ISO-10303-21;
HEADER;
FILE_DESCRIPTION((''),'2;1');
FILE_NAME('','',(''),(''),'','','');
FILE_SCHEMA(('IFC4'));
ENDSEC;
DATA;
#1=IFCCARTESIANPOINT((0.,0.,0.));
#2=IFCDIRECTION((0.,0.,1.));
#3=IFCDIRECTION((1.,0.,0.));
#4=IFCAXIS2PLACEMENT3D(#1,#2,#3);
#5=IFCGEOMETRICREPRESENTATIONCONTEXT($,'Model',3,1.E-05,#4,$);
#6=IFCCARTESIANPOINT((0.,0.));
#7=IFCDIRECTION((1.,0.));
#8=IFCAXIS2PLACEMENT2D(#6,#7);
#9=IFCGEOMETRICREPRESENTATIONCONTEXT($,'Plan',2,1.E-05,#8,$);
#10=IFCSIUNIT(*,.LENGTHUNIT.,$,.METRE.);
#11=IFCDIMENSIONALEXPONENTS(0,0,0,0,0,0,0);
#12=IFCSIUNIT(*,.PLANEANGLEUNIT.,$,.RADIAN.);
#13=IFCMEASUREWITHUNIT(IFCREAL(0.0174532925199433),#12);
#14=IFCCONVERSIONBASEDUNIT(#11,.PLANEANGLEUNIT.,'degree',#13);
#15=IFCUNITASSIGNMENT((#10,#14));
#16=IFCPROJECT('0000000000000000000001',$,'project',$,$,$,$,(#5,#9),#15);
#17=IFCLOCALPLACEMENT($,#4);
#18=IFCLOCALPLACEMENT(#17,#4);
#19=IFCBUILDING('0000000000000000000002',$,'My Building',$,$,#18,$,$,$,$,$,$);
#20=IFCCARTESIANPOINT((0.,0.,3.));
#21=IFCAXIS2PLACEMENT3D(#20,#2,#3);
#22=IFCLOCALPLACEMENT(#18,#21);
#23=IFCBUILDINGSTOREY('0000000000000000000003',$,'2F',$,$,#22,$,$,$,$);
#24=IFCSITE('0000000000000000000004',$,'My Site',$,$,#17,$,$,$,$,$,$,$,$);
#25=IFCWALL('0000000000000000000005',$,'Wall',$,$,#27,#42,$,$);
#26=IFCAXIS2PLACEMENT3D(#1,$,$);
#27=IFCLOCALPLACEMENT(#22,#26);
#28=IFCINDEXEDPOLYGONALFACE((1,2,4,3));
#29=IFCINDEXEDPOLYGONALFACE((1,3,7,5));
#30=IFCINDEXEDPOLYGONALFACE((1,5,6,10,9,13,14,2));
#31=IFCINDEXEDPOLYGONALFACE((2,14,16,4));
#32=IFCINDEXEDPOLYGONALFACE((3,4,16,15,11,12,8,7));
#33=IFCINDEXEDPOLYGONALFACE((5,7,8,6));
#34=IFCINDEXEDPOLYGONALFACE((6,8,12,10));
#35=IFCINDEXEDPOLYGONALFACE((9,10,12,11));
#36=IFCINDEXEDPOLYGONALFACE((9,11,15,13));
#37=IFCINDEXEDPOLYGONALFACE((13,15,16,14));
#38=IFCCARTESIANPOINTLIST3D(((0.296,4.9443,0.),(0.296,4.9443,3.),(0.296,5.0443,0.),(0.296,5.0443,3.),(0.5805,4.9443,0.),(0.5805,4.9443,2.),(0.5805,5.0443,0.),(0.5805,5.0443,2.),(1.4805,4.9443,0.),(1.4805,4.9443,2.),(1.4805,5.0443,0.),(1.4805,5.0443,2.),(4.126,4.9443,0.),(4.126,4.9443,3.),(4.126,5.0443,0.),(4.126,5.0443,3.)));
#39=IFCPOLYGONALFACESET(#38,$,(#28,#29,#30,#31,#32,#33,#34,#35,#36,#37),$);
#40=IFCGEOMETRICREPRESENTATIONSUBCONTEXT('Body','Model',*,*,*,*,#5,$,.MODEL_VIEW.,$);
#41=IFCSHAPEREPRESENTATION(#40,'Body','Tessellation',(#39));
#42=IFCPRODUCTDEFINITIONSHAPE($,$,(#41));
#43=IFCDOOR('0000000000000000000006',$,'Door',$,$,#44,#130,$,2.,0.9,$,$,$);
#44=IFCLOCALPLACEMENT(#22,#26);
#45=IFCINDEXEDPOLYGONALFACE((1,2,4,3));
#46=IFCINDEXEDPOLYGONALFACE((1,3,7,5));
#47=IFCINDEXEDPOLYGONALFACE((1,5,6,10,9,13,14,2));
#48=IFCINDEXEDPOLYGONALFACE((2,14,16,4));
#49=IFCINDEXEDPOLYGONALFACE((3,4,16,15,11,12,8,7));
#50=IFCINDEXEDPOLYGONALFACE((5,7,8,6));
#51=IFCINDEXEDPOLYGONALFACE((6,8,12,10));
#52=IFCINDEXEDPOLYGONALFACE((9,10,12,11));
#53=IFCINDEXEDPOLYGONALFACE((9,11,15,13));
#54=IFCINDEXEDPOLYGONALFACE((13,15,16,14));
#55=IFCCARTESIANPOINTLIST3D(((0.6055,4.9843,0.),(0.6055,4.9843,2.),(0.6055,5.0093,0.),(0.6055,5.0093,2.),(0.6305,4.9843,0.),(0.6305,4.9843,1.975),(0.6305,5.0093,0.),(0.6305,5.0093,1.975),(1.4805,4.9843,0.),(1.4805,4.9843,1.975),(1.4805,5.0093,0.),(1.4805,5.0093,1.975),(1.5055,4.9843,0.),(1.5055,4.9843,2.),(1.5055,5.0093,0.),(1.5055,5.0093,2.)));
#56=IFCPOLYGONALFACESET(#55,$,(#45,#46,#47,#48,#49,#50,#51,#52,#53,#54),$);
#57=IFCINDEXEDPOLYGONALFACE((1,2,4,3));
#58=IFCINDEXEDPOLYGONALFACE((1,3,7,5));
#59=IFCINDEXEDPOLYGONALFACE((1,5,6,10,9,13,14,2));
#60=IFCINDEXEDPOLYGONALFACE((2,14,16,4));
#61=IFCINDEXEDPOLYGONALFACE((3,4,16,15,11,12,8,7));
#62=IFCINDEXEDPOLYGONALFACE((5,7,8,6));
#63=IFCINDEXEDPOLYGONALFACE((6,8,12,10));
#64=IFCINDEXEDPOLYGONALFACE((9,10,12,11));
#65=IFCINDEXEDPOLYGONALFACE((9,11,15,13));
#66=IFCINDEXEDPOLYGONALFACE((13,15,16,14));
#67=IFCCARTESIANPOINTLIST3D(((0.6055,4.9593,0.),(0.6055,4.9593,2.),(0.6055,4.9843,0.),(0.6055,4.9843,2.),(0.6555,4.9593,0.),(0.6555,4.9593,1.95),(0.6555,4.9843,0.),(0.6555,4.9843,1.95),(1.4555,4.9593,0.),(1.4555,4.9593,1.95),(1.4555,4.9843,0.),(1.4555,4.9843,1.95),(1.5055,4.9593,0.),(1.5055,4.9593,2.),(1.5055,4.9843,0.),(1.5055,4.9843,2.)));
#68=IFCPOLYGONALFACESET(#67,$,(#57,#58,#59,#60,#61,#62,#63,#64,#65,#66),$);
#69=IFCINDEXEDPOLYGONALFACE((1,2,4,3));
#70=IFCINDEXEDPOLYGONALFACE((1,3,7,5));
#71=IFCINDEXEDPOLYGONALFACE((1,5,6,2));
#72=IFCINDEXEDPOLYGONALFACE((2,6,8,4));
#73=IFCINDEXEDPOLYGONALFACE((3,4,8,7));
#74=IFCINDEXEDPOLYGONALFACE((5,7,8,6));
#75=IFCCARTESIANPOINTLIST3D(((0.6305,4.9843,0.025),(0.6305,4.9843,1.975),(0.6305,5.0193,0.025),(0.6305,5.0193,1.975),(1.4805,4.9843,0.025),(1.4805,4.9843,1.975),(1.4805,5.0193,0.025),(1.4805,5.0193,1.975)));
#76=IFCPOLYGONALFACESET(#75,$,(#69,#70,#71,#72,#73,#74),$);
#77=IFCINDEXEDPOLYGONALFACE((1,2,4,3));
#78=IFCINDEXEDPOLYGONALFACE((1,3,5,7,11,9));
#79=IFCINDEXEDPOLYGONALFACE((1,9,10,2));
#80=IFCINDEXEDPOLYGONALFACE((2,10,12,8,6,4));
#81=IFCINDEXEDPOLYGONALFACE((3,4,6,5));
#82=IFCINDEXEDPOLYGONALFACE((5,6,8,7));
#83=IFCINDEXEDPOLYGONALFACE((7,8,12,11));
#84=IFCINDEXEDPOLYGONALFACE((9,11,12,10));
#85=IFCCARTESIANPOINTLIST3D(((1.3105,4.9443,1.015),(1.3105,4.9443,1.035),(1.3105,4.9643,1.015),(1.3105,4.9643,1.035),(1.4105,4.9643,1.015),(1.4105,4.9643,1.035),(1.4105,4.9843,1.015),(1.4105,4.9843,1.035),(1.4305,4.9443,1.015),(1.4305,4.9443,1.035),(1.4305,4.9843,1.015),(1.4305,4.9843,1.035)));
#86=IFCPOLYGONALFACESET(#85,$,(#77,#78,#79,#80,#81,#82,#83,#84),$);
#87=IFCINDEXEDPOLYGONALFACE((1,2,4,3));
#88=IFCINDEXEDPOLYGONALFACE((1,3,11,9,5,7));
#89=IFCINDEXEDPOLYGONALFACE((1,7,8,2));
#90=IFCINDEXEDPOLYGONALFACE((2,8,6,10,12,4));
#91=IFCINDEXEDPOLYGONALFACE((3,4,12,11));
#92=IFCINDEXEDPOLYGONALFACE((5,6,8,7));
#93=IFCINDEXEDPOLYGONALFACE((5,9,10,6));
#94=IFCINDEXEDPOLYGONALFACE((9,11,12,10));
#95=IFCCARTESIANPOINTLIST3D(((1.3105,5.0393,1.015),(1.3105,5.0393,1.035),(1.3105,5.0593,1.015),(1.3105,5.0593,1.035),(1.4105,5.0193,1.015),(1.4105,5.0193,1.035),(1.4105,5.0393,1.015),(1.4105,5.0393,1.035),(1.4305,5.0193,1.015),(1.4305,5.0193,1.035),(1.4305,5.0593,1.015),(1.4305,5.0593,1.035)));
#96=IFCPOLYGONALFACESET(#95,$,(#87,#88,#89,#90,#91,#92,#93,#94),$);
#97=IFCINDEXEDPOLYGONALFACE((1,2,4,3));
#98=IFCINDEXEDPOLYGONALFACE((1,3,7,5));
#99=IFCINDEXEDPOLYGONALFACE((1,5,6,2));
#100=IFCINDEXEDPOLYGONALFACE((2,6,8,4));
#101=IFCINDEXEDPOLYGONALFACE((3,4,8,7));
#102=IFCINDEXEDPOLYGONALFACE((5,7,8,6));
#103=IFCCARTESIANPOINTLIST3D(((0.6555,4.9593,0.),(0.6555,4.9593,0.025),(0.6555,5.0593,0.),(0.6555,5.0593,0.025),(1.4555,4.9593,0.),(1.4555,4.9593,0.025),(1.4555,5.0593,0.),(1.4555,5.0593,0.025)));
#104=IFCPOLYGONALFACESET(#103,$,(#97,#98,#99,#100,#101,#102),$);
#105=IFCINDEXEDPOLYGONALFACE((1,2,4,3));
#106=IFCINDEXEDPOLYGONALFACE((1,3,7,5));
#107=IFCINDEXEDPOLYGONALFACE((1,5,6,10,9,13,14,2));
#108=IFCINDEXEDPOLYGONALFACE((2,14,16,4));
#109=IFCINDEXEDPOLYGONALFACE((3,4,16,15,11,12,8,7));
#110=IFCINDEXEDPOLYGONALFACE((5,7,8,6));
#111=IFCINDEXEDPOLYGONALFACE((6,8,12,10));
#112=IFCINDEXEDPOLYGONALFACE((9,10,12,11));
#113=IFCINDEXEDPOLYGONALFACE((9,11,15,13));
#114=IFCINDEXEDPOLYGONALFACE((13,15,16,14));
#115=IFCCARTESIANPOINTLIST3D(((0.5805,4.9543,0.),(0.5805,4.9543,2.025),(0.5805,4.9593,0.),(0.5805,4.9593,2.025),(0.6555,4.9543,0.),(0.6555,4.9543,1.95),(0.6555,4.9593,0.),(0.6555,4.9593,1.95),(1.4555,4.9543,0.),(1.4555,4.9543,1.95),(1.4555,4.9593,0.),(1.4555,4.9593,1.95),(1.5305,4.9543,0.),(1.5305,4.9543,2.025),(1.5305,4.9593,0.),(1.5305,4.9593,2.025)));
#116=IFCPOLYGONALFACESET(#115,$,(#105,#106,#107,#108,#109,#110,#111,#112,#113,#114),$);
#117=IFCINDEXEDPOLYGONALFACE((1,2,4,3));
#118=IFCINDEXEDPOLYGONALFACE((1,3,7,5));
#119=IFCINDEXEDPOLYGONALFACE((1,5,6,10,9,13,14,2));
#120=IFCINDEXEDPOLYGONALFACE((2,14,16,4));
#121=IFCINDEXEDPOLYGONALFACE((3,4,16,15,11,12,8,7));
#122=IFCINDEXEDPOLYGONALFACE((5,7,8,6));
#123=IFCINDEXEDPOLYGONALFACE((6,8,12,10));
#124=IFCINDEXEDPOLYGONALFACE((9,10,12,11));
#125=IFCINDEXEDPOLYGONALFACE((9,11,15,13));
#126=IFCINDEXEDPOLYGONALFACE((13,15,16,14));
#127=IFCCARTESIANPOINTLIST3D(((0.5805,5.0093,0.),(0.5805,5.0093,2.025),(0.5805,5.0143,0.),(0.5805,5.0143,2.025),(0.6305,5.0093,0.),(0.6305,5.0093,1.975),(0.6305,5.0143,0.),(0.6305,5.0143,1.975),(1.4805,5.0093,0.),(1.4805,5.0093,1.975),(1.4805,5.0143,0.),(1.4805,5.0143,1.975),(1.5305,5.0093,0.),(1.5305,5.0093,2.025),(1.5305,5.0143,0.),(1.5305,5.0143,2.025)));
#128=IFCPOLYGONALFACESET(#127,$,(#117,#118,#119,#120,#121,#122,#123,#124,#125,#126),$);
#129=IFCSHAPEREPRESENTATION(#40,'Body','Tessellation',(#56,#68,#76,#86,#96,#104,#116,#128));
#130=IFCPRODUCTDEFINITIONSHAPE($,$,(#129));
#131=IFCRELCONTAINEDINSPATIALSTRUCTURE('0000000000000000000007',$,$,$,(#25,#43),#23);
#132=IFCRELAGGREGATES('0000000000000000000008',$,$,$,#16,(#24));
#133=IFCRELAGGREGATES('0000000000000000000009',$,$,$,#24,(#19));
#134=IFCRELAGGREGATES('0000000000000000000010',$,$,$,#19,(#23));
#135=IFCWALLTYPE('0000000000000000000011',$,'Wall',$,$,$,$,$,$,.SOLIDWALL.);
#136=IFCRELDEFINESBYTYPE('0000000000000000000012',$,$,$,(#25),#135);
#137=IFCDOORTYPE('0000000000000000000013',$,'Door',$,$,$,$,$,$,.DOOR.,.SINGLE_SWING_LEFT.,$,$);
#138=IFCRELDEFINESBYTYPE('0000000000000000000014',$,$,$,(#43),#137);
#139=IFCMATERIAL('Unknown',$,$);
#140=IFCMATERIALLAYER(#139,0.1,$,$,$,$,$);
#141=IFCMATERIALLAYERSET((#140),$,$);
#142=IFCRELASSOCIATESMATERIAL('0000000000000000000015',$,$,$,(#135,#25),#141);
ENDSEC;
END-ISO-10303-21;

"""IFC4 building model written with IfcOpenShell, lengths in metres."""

from ifc_helpers import new_model, entity, si_unit, converted_unit, frame, origin_with_axes, origin_2d_with_axis, place, context, subcontext, project, spatial, line, indexed_curve, outline, extrude, shape, source, transform, mapped, material, layer, layer_set, layer_usage, type_object, type_shapes, element, fill, save


model = new_model("IFC4")

# Units and contexts
model_context = context("Model", 3, precision=1e-05, world=origin_with_axes())
plan_context = context("Plan", 2, precision=1e-05, world=origin_2d_with_axis())
body_context_1 = subcontext(model_context, "Body", "Model", "MODEL_VIEW")
body_context_2 = subcontext(plan_context, "Body", "Plan", "PLAN_VIEW")
ifc_project = project(units=[si_unit("LENGTHUNIT", "METRE"), converted_unit("PLANEANGLEUNIT", "degree", entity("IfcReal", 0.0174532925199433), si_unit("PLANEANGLEUNIT", "RADIAN"), dimensions=[0, 0, 0, 0, 0, 0, 0])], contexts=[model_context, plan_context])

# Site, building, storey
site_placement = place(None, origin_with_axes())
site = spatial("IfcSite", under=ifc_project, at=site_placement, Name="My Site")
building_placement = place(site_placement, origin_with_axes())
building = spatial("IfcBuilding", under=site, at=building_placement, Name="My Building")
storey_placement = place(building_placement, frame((0.0, 0.0, 3.0), z_axis=(0.0, 0.0, 1.0), x_axis=(1.0, 0.0, 0.0)))
storey = spatial("IfcBuildingStorey", under=building, at=storey_placement, Name="2F")

# Shared definitions
ifc_material = material(Name="Unknown")

# Shared definitions
ifc_layer_1 = layer(ifc_material, 0.1)
ifc_layer_set_1 = layer_set([ifc_layer_1])
wall_type = type_object("IfcWallType", Name="Wall", PredefinedType="SOLIDWALL", material=ifc_layer_set_1)

# Shared definitions
shared_shape_1 = source(origin_with_axes(), body_context_1, "Body", "SweptSolid", [
    extrude(outline(indexed_curve([(0.0, 0.0), (0.9, 0.0), (0.9, 2.0), (0.0, 2.0)], segments=[line(1, 2, 3, 4, 1)])), frame((0.0, -0.6, 0.0), z_axis=(0.0, -1.0, 0.0), x_axis=(1.0, 0.0, 0.0)), (0.0, 0.0, -1.0), 1.2),
])
door_type_1 = type_object("IfcDoorType", Name="Door", OperationType="SINGLE_SWING_LEFT", PredefinedType="DOOR")
shared_shape_2 = source(origin_with_axes(), body_context_1, "Body", "SweptSolid", [
    extrude(outline(indexed_curve([(0.0, 0.0), (0.0, 2.0), (0.9, 2.0), (0.9, 0.0), (0.875, 0.0), (0.875, 1.975), (0.025, 1.975), (0.025, 0.0)], segments=[line(1, 2, 3, 4, 5, 6, 7, 8, 1)])), frame((0.0, 0.025, 0.0), z_axis=(0.0, -1.0, 0.0), x_axis=(1.0, 0.0, 0.0)), (0.0, 0.0, -1.0), 0.025),
    extrude(outline(indexed_curve([(0.0, 0.0), (0.0, 2.0), (0.9, 2.0), (0.9, 0.0), (0.85, 0.0), (0.85, 1.95), (0.05, 1.95), (0.05, 0.0)], segments=[line(1, 2, 3, 4, 5, 6, 7, 8, 1)])), frame((0.0, 0.0, 0.0), z_axis=(0.0, -1.0, 0.0), x_axis=(1.0, 0.0, 0.0)), (0.0, 0.0, -1.0), 0.025),
    extrude(outline(indexed_curve([(0.0, 0.0), (0.85, 0.0), (0.85, 0.035), (0.0, 0.035)], segments=[line(1, 2, 3, 4, 1)])), frame((0.025, 0.025, 0.025), z_axis=(0.0, 0.0, 1.0), x_axis=(1.0, 0.0, 0.0)), (0.0, 0.0, 1.0), 1.95),
    extrude(outline(indexed_curve([(0.0, 0.0), (0.0, -0.04), (-0.12, -0.04), (-0.12, -0.02), (-0.02, -0.02), (-0.02, 0.0)], segments=[line(1, 2, 3, 4, 5, 6, 1)])), frame((0.825, 0.025, 1.015), z_axis=(0.0, 0.0, 1.0), x_axis=(1.0, 0.0, 0.0)), (0.0, 0.0, 1.0), 0.02),
    extrude(outline(indexed_curve([(0.0, 0.0), (0.0, 0.04), (-0.12, 0.04), (-0.12, 0.02), (-0.02, 0.02), (-0.02, 0.0)], segments=[line(1, 2, 3, 4, 5, 6, 1)])), frame((0.825, 0.06, 1.015), z_axis=(0.0, 0.0, 1.0), x_axis=(1.0, 0.0, 0.0)), (0.0, 0.0, 1.0), 0.02),
    extrude(outline(indexed_curve([(0.0, 0.0), (0.8, 0.0), (0.8, 0.1), (0.0, 0.1)], segments=[line(1, 2, 3, 4, 1)])), frame((0.05, 0.0, 0.0), z_axis=(0.0, 0.0, 1.0), x_axis=(1.0, 0.0, 0.0)), (0.0, 0.0, 1.0), 0.025),
    extrude(outline(indexed_curve([(0.0, 0.0), (0.0, 2.025), (0.95, 2.025), (0.95, 0.0), (0.875, 0.0), (0.875, 1.95), (0.075, 1.95), (0.075, 0.0)], segments=[line(1, 2, 3, 4, 5, 6, 7, 8, 1)])), frame((-0.025, -0.005, 0.0), z_axis=(0.0, -1.0, 0.0), x_axis=(1.0, 0.0, 0.0)), (0.0, 0.0, -1.0), 0.005),
    extrude(outline(indexed_curve([(0.0, 0.0), (0.0, 2.025), (0.95, 2.025), (0.95, 0.0), (0.9, 0.0), (0.9, 1.975), (0.05, 1.975), (0.05, 0.0)], segments=[line(1, 2, 3, 4, 5, 6, 7, 8, 1)])), frame((-0.025, 0.05, 0.0), z_axis=(0.0, -1.0, 0.0), x_axis=(1.0, 0.0, 0.0)), (0.0, 0.0, -1.0), 0.005),
])
shared_shape_3 = source(origin_with_axes(), body_context_2, "Body", "Curve2D", [
    entity("IfcIndexedPolyCurve", entity("IfcCartesianPointList2D", [[0.0, 0.0], [0.0, 0.05], [0.025, 0.05], [0.025, 0.025], [0.05, 0.025], [0.05, 0.0]]), [entity("IfcLineIndex", [1, 2, 3, 4, 5, 6, 1])]),
    entity("IfcIndexedPolyCurve", entity("IfcCartesianPointList2D", [[0.9, 0.0], [0.9, 0.05], [0.875, 0.05], [0.875, 0.025], [0.85, 0.025], [0.85, 0.0]]), [entity("IfcLineIndex", [1, 2, 3, 4, 5, 6, 1])]),
    entity("IfcTrimmedCurve", entity("IfcEllipse", entity("IfcAxis2Placement2D", entity("IfcCartesianPoint", [0.06, 0.05]), entity("IfcDirection", [1.0, 0.0])), 0.815, 0.85), [entity("IfcCartesianPoint", [0.875, 0.05])], [entity("IfcCartesianPoint", [0.06, 0.9])], True, "CARTESIAN"),
    entity("IfcIndexedPolyCurve", entity("IfcCartesianPointList2D", [[0.025, 0.05], [0.06, 0.05], [0.06, 0.9], [0.025, 0.9]]), [entity("IfcLineIndex", [1, 2, 3, 4, 1])]),
])
type_shapes(door_type_1, [shared_shape_2, shared_shape_3])

# Wall, opening, door
ifc_layer_usage_1 = layer_usage(ifc_layer_set_1, "AXIS2", "POSITIVE", 0.0)
wall_1_placement = place(storey_placement, frame((4.126, 5.0443, 0.0), z_axis=(0.0, 0.0, 1.0), x_axis=(-1.0, -0.000001, 0.0)))
wall_1 = element("IfcWall", 1, at=wall_1_placement, inside=storey, type_object=wall_type, material=ifc_layer_usage_1, Name="Wall", context=body_context_1, shape_type="SweptSolid", body=[
    extrude(outline(indexed_curve([(0.0, 0.0), (0.0, 0.1), (3.83, 0.1), (3.83, 0.0)], segments=[line(1, 2, 3, 4, 1)])), origin_with_axes(), (0.0, 0.0, 1.0), 3.0),
])
opening_1_placement = place(wall_1_placement, frame((2.6455, 0.0, 0.0), z_axis=(0.0, 0.0, 1.0), x_axis=(1.0, 0.0, 0.0)))
opening_1 = element("IfcOpeningElement", 2, at=opening_1_placement, cuts=wall_1, PredefinedType="OPENING", context=body_context_1, shape_type="MappedRepresentation", body=[
    mapped(shared_shape_1, transform((0.0, 0.0, 0.0), x_axis=(1.0, 0.0, 0.0), y_axis=(0.0, 1.0, 0.0), z_axis=(0.0, 0.0, 1.0), scale=1.0)),
])
door_1_placement = place(opening_1_placement, frame((0.875, 0.085, 0.0), z_axis=(0.0, 0.0, 1.0), x_axis=(-1.0, 0.0, 0.0)))
door_1 = element("IfcDoor", 3, at=door_1_placement, inside=storey, type_object=door_type_1, Name="Door", OverallHeight=2.0, OverallWidth=0.9, shapes=[
    shape(body_context_1, "Body", "MappedRepresentation", [mapped(shared_shape_2, transform((0.0, 0.0, 0.0), x_axis=(1.0, 0.0, 0.0), y_axis=(0.0, 1.0, 0.0), z_axis=(0.0, 0.0, 1.0), scale=1.0))]),
    shape(body_context_2, "Body", "MappedRepresentation", [mapped(shared_shape_3, transform((0.0, 0.0, 0.0), x_axis=(1.0, 0.0, 0.0), y_axis=(0.0, 1.0, 0.0), z_axis=(0.0, 0.0, 1.0), scale=1.0))]),
])
fill(opening_1, door_1)

save(model, "model.ifc")
